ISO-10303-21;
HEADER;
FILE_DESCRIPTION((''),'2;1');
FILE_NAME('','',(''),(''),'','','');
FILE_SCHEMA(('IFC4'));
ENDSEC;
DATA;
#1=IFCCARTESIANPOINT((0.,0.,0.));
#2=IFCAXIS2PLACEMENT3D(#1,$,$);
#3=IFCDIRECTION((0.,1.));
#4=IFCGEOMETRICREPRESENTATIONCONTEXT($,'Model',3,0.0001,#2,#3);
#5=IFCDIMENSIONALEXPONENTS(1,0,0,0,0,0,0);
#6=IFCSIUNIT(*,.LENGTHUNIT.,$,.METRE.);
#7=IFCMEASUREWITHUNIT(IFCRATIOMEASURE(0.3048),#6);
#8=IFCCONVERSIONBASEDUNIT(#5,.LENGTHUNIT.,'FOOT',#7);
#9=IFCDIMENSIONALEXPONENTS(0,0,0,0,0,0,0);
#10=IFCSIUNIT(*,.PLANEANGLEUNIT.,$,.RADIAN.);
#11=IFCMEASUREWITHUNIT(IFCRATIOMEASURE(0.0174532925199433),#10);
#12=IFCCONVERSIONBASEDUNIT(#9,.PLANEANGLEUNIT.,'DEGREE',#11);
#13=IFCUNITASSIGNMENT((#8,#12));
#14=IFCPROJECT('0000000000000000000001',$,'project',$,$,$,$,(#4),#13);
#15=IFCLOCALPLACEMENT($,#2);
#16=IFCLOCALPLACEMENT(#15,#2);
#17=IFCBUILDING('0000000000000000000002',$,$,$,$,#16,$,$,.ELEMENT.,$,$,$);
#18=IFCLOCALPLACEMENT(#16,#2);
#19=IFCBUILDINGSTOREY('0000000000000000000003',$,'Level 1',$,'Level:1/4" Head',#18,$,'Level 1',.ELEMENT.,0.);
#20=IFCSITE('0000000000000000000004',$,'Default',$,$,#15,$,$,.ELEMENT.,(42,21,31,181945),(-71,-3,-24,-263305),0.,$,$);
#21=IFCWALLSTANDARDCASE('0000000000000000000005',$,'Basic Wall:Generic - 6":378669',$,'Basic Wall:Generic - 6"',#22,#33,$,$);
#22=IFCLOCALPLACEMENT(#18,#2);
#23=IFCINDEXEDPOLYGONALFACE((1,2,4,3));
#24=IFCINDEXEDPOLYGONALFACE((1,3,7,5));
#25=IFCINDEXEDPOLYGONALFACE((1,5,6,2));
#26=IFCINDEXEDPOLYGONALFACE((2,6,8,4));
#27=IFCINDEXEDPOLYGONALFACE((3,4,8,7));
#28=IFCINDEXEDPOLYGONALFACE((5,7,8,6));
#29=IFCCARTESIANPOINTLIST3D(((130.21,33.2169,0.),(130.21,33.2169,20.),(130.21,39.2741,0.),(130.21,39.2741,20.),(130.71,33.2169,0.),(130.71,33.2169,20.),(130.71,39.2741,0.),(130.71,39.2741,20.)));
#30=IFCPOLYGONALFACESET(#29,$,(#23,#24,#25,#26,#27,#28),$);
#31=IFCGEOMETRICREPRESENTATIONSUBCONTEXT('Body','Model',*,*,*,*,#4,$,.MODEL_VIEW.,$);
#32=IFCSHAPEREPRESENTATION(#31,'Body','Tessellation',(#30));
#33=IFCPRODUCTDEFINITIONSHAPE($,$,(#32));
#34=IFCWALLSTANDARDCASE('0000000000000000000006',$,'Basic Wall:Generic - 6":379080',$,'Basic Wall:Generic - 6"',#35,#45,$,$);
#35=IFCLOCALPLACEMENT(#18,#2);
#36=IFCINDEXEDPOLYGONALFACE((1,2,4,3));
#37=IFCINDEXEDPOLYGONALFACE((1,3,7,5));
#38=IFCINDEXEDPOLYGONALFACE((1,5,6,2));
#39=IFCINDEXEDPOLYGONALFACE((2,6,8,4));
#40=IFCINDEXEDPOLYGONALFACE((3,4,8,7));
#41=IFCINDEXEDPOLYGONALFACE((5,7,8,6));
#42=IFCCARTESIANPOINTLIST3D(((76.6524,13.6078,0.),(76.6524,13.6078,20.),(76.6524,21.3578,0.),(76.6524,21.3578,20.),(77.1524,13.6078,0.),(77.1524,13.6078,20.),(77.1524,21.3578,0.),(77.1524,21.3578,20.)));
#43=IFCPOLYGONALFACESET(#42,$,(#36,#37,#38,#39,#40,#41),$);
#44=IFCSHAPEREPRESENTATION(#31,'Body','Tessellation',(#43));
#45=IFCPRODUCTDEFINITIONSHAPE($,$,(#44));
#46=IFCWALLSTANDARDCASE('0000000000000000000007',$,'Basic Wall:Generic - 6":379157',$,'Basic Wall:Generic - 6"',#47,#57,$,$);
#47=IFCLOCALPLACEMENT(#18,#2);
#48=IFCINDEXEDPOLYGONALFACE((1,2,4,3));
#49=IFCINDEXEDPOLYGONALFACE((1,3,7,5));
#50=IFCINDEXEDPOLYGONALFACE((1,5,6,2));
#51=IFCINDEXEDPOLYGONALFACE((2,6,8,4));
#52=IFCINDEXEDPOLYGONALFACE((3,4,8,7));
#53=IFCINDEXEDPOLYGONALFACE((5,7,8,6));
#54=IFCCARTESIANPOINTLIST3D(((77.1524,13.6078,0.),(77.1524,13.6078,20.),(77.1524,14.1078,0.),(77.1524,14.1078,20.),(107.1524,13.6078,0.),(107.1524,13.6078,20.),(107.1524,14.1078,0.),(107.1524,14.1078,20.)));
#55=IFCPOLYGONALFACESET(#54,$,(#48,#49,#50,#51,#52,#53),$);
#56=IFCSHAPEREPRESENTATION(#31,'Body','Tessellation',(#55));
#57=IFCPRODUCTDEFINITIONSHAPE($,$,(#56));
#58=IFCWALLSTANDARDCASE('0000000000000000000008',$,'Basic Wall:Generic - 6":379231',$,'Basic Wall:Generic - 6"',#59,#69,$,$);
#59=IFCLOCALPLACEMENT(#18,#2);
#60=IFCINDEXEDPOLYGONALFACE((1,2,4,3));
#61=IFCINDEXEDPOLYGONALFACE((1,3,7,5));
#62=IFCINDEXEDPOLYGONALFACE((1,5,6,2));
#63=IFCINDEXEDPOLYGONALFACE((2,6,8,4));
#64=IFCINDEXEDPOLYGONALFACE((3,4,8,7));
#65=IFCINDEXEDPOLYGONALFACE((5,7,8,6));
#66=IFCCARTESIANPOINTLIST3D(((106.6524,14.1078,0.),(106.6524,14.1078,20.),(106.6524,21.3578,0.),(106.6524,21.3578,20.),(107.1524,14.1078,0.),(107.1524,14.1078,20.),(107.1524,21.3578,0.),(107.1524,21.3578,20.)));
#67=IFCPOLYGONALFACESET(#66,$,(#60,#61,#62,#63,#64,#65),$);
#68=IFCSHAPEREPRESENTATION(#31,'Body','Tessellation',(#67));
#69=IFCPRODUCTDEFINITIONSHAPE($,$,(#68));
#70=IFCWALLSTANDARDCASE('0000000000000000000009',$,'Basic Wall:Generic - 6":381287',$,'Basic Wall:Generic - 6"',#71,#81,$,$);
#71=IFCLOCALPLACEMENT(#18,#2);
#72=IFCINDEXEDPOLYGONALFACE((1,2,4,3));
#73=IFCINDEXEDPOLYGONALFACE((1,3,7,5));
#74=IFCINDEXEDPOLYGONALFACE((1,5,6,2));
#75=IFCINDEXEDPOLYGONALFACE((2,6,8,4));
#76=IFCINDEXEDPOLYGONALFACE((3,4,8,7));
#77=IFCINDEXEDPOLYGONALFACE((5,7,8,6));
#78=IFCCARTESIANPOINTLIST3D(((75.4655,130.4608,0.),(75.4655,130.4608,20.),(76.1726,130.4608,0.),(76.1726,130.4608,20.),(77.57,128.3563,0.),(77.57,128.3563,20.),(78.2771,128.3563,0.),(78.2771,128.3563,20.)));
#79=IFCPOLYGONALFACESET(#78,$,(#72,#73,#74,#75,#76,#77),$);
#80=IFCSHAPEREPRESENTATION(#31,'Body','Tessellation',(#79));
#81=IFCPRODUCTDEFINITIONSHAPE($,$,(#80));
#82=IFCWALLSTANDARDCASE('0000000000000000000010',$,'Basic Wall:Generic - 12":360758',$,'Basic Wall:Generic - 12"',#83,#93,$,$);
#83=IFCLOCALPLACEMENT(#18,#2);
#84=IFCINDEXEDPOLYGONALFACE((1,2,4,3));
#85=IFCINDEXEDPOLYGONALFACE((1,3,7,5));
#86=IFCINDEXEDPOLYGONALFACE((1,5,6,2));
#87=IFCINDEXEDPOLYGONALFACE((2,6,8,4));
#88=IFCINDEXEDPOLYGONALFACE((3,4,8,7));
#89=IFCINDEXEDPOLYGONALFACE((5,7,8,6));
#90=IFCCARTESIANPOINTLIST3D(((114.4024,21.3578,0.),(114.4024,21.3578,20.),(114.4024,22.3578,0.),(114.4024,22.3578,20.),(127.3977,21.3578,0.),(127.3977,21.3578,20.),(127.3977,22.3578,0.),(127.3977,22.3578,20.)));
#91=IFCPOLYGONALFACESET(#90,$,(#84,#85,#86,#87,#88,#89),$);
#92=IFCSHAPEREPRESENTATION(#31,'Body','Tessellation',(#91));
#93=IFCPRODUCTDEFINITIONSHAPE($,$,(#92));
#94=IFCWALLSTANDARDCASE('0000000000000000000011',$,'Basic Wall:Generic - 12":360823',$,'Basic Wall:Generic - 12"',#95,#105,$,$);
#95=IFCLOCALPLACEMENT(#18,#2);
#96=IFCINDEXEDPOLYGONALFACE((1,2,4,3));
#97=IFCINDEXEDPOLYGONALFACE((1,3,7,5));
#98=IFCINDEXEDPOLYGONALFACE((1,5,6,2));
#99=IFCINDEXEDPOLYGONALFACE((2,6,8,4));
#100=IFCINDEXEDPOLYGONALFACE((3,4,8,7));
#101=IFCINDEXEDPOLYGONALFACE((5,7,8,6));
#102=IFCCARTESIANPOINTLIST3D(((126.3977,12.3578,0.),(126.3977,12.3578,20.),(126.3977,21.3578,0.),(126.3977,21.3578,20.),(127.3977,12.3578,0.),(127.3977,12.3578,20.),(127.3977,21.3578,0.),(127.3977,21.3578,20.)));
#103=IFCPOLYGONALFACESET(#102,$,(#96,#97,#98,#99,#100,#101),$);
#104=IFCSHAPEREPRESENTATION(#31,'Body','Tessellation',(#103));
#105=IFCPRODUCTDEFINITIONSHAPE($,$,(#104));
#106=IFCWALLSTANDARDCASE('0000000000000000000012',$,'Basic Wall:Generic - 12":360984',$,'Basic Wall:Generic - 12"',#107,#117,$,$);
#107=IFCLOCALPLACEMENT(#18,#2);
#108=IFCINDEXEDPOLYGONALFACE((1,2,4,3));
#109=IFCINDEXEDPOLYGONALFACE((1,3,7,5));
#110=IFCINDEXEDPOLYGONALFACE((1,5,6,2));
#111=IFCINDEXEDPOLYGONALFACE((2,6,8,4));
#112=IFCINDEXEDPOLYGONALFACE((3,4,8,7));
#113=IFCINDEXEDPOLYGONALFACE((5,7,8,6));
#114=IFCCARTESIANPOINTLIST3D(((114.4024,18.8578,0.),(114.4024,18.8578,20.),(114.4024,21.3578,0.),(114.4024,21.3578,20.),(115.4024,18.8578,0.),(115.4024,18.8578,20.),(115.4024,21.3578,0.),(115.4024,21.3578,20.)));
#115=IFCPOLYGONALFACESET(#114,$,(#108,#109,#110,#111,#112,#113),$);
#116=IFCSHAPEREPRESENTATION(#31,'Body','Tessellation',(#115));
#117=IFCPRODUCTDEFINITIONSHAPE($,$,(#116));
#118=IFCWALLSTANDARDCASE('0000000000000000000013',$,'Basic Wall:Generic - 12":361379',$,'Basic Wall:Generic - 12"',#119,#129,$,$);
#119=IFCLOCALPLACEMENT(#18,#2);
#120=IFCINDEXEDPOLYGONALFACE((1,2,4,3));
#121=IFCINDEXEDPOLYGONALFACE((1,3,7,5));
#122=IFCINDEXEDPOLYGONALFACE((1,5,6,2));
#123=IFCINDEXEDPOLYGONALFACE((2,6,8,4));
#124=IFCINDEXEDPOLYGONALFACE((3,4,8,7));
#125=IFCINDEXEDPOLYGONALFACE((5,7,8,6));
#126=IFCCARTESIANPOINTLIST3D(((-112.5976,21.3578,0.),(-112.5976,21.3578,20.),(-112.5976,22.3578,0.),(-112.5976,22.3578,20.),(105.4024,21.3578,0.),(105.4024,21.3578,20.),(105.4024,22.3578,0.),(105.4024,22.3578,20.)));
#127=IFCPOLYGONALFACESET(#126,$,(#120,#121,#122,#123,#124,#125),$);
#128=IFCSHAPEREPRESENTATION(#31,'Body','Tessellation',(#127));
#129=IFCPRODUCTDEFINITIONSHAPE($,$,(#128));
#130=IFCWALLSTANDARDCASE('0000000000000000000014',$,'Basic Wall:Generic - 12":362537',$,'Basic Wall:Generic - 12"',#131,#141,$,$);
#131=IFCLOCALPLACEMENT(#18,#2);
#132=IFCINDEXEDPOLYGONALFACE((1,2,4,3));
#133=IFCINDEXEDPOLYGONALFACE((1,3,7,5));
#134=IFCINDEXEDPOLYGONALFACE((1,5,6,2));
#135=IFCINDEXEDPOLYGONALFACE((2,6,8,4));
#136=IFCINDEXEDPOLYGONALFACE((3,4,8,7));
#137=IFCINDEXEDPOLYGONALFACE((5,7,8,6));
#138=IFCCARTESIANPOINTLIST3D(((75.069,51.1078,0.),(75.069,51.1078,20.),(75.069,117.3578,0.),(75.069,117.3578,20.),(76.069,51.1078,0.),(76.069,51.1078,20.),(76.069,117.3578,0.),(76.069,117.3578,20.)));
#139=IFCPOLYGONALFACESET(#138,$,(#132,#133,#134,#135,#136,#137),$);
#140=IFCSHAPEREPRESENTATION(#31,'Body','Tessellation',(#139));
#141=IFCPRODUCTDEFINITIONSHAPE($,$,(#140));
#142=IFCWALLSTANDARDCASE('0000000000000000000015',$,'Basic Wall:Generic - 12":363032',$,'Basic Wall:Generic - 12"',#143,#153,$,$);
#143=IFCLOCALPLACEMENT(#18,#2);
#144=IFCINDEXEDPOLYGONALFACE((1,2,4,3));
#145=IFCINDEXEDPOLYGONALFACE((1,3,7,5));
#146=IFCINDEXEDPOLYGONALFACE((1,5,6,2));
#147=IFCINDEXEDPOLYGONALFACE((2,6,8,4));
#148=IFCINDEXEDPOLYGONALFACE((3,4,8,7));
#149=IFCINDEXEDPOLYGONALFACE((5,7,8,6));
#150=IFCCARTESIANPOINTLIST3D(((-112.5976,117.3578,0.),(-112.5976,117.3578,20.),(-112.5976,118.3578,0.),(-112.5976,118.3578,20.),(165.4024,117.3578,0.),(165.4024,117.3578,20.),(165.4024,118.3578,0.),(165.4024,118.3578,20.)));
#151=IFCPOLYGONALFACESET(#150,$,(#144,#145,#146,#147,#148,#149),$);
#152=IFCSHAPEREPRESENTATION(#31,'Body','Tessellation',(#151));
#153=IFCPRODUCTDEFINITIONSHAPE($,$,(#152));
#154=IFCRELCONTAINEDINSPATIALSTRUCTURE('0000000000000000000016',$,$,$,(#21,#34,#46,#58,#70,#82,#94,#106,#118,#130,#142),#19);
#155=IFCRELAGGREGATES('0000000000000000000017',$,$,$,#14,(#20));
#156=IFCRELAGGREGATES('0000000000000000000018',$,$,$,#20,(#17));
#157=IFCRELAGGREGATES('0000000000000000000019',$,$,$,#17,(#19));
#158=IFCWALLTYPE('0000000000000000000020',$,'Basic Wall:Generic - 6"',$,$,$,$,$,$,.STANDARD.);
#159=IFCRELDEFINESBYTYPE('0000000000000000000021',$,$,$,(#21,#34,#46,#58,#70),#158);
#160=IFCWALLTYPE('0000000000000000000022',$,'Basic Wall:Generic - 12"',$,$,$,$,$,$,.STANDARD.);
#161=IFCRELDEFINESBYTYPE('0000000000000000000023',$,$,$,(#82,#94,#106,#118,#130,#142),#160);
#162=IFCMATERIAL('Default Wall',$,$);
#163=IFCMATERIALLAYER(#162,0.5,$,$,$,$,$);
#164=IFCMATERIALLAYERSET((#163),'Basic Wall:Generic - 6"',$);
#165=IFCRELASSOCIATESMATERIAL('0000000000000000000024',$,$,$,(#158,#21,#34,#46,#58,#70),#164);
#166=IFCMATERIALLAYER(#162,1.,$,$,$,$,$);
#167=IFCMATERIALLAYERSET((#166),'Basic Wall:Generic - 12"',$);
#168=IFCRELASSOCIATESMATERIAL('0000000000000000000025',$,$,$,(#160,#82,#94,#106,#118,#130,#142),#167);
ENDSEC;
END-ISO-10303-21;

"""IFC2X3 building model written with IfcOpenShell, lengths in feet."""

from ifc_helpers import new_model, entity, si_unit, converted_unit, direction, frame, frame_2d, origin, place, context, subcontext, project, spatial, polyline, rectangle, outline, extrude, material, layer, layer_set, layer_usage, type_object, element, save


model = new_model("IFC2X3")

# Units and contexts
model_context = context("Model", 3, precision=0.0001, world=origin(), true_north=direction((0.0, 1.0)))
body_context = subcontext(model_context, "Body", "Model", "MODEL_VIEW")
ifc_project = project(units=[converted_unit("LENGTHUNIT", "FOOT", entity("IfcRatioMeasure", 0.3048), si_unit("LENGTHUNIT", "METRE"), dimensions=[1, 0, 0, 0, 0, 0, 0]), converted_unit("PLANEANGLEUNIT", "DEGREE", entity("IfcRatioMeasure", 0.0174532925199433), si_unit("PLANEANGLEUNIT", "RADIAN"), dimensions=[0, 0, 0, 0, 0, 0, 0])], contexts=[model_context])

# Site, building, storey
site_placement = place(None, origin())
site = spatial("IfcSite", under=ifc_project, at=site_placement, Name="Default", CompositionType="ELEMENT", RefLatitude=(42, 21, 31, 181945), RefLongitude=(-71, -3, -24, -263305), RefElevation=0.0)
building_placement = place(site_placement, origin())
building = spatial("IfcBuilding", under=site, at=building_placement, CompositionType="ELEMENT")
storey_placement = place(building_placement, origin())
storey = spatial("IfcBuildingStorey", under=building, at=storey_placement, Name="Level 1", ObjectType="Level:1/4\" Head", LongName="Level 1", CompositionType="ELEMENT", Elevation=0.0)

# Walls
ifc_material = material(Name="Default Wall")
ifc_layer_1 = layer(ifc_material, 0.5)
ifc_layer_set_1 = layer_set([ifc_layer_1], Name="Basic Wall:Generic - 6\"")
wall_type_1 = type_object("IfcWallType", Name="Basic Wall:Generic - 6\"", PredefinedType="STANDARD", material=ifc_layer_set_1)
ifc_layer_usage_1 = layer_usage(ifc_layer_set_1, "AXIS2", "NEGATIVE", 0.25)
wall_1_placement = place(storey_placement, frame((130.46, 39.2741, 0.0), z_axis=(0.0, 0.0, 1.0), x_axis=(0.0, -1.0, 0.0)))
element("IfcWallStandardCase", 1, at=wall_1_placement, inside=storey, type_object=wall_type_1, material=ifc_layer_usage_1, Name="Basic Wall:Generic - 6\":378669", ObjectType="Basic Wall:Generic - 6\"", context=body_context, shape_type="SweptSolid", body=[
    extrude(rectangle(XDim=6.0572, YDim=0.5, at=frame_2d((3.0286, 0.0), x_axis=(-1.0, 0.0))), origin(), (0.0, 0.0, 1.0), 20.0),
])
ifc_layer_usage_2 = layer_usage(ifc_layer_set_1, "AXIS2", "NEGATIVE", 0.25)
wall_2_placement = place(storey_placement, frame((76.9024, 21.3578, 0.0), z_axis=(0.0, 0.0, 1.0), x_axis=(0.0, -1.0, 0.0)))
element("IfcWallStandardCase", 2, at=wall_2_placement, inside=storey, type_object=wall_type_1, material=ifc_layer_usage_2, Name="Basic Wall:Generic - 6\":379080", ObjectType="Basic Wall:Generic - 6\"", context=body_context, shape_type="SweptSolid", body=[
    extrude(rectangle(XDim=7.75, YDim=0.5, at=frame_2d((3.875, 0.0), x_axis=(-1.0, 0.0))), origin(), (0.0, 0.0, 1.0), 20.0),
])
ifc_layer_usage_3 = layer_usage(ifc_layer_set_1, "AXIS2", "NEGATIVE", 0.25)
wall_3_placement = place(storey_placement, frame((77.1524, 13.8578, 0.0)))
element("IfcWallStandardCase", 3, at=wall_3_placement, inside=storey, type_object=wall_type_1, material=ifc_layer_usage_3, Name="Basic Wall:Generic - 6\":379157", ObjectType="Basic Wall:Generic - 6\"", context=body_context, shape_type="SweptSolid", body=[
    extrude(rectangle(XDim=30.0, YDim=0.5, at=frame_2d((15.0, 0.0), x_axis=(-1.0, 0.0))), origin(), (0.0, 0.0, 1.0), 20.0),
])
ifc_layer_usage_4 = layer_usage(ifc_layer_set_1, "AXIS2", "NEGATIVE", 0.25)
wall_4_placement = place(storey_placement, frame((106.9024, 14.1078, 0.0), z_axis=(0.0, 0.0, 1.0), x_axis=(0.0, 1.0, 0.0)))
element("IfcWallStandardCase", 4, at=wall_4_placement, inside=storey, type_object=wall_type_1, material=ifc_layer_usage_4, Name="Basic Wall:Generic - 6\":379231", ObjectType="Basic Wall:Generic - 6\"", context=body_context, shape_type="SweptSolid", body=[
    extrude(rectangle(XDim=7.25, YDim=0.5, at=frame_2d((3.625, 0.0), x_axis=(-1.0, 0.0))), origin(), (0.0, 0.0, 1.0), 20.0),
])
ifc_layer_usage_5 = layer_usage(ifc_layer_set_1, "AXIS2", "NEGATIVE", 0.25)
wall_5_placement = place(storey_placement, frame((75.6422, 130.6376, 0.0), z_axis=(0.0, 0.0, 1.0), x_axis=(0.707107, -0.707107, 0.0)))
element("IfcWallStandardCase", 5, at=wall_5_placement, inside=storey, type_object=wall_type_1, material=ifc_layer_usage_5, Name="Basic Wall:Generic - 6\":381287", ObjectType="Basic Wall:Generic - 6\"", context=body_context, shape_type="SweptSolid", body=[
    extrude(outline(polyline([(2.9762, -0.25), (3.4762, 0.25), (0.5, 0.25), (0.0, -0.25), (2.9762, -0.25)])), origin(), (0.0, 0.0, 1.0), 20.0),
])
ifc_layer_2 = layer(ifc_material, 1.0)
ifc_layer_set_2 = layer_set([ifc_layer_2], Name="Basic Wall:Generic - 12\"")
ifc_layer_usage_6 = layer_usage(ifc_layer_set_2, "AXIS2", "NEGATIVE", 0.5)
wall_type_2 = type_object("IfcWallType", Name="Basic Wall:Generic - 12\"", PredefinedType="STANDARD", material=ifc_layer_set_2)
wall_6_placement = place(storey_placement, frame((114.4024, 21.8578, 0.0)))
element("IfcWallStandardCase", 6, at=wall_6_placement, inside=storey, type_object=wall_type_2, material=ifc_layer_usage_6, Name="Basic Wall:Generic - 12\":360758", ObjectType="Basic Wall:Generic - 12\"", context=body_context, shape_type="SweptSolid", body=[
    extrude(rectangle(XDim=12.9953, YDim=1.0, at=frame_2d((6.4977, 0.0), x_axis=(-1.0, 0.0))), origin(), (0.0, 0.0, 1.0), 20.0),
])
ifc_layer_usage_7 = layer_usage(ifc_layer_set_2, "AXIS2", "NEGATIVE", 0.5)
wall_7_placement = place(storey_placement, frame((126.8977, 21.3578, 0.0), z_axis=(0.0, 0.0, 1.0), x_axis=(0.0, -1.0, 0.0)))
element("IfcWallStandardCase", 7, at=wall_7_placement, inside=storey, type_object=wall_type_2, material=ifc_layer_usage_7, Name="Basic Wall:Generic - 12\":360823", ObjectType="Basic Wall:Generic - 12\"", context=body_context, shape_type="SweptSolid", body=[
    extrude(rectangle(XDim=9.0, YDim=1.0, at=frame_2d((4.5, 0.0), x_axis=(-1.0, 0.0))), origin(), (0.0, 0.0, 1.0), 20.0),
])
ifc_layer_usage_8 = layer_usage(ifc_layer_set_2, "AXIS2", "NEGATIVE", 0.5)
wall_8_placement = place(storey_placement, frame((114.9024, 18.8578, 0.0), z_axis=(0.0, 0.0, 1.0), x_axis=(0.0, 1.0, 0.0)))
element("IfcWallStandardCase", 8, at=wall_8_placement, inside=storey, type_object=wall_type_2, material=ifc_layer_usage_8, Name="Basic Wall:Generic - 12\":360984", ObjectType="Basic Wall:Generic - 12\"", context=body_context, shape_type="SweptSolid", body=[
    extrude(rectangle(XDim=2.5, YDim=1.0, at=frame_2d((1.25, 0.0), x_axis=(-1.0, 0.0))), origin(), (0.0, 0.0, 1.0), 20.0),
])
ifc_layer_usage_9 = layer_usage(ifc_layer_set_2, "AXIS2", "NEGATIVE", 0.5)
wall_9_placement = place(storey_placement, frame((105.4024, 21.8578, 0.0), z_axis=(0.0, 0.0, 1.0), x_axis=(-1.0, 0.0, 0.0)))
element("IfcWallStandardCase", 9, at=wall_9_placement, inside=storey, type_object=wall_type_2, material=ifc_layer_usage_9, Name="Basic Wall:Generic - 12\":361379", ObjectType="Basic Wall:Generic - 12\"", context=body_context, shape_type="SweptSolid", body=[
    extrude(rectangle(XDim=218.0, YDim=1.0, at=frame_2d((109.0, 0.0), x_axis=(-1.0, 0.0))), origin(), (0.0, 0.0, 1.0), 20.0),
])
ifc_layer_usage_10 = layer_usage(ifc_layer_set_2, "AXIS2", "NEGATIVE", 0.5)
wall_10_placement = place(storey_placement, frame((75.569, 117.3578, 0.0), z_axis=(0.0, 0.0, 1.0), x_axis=(0.0, -1.0, 0.0)))
element("IfcWallStandardCase", 10, at=wall_10_placement, inside=storey, type_object=wall_type_2, material=ifc_layer_usage_10, Name="Basic Wall:Generic - 12\":362537", ObjectType="Basic Wall:Generic - 12\"", context=body_context, shape_type="SweptSolid", body=[
    extrude(rectangle(XDim=66.25, YDim=1.0, at=frame_2d((33.125, 0.0), x_axis=(-1.0, 0.0))), origin(), (0.0, 0.0, 1.0), 20.0),
])
ifc_layer_usage_11 = layer_usage(ifc_layer_set_2, "AXIS2", "NEGATIVE", 0.5)
wall_11_placement = place(storey_placement, frame((165.4024, 117.8578, 0.0), z_axis=(0.0, 0.0, 1.0), x_axis=(-1.0, 0.0, 0.0)))
element("IfcWallStandardCase", 11, at=wall_11_placement, inside=storey, type_object=wall_type_2, material=ifc_layer_usage_11, Name="Basic Wall:Generic - 12\":363032", ObjectType="Basic Wall:Generic - 12\"", context=body_context, shape_type="SweptSolid", body=[
    extrude(rectangle(XDim=278.0, YDim=1.0, at=frame_2d((139.0, 0.0), x_axis=(-1.0, 0.0))), origin(), (0.0, 0.0, 1.0), 20.0),
])

save(model, "model.ifc")
